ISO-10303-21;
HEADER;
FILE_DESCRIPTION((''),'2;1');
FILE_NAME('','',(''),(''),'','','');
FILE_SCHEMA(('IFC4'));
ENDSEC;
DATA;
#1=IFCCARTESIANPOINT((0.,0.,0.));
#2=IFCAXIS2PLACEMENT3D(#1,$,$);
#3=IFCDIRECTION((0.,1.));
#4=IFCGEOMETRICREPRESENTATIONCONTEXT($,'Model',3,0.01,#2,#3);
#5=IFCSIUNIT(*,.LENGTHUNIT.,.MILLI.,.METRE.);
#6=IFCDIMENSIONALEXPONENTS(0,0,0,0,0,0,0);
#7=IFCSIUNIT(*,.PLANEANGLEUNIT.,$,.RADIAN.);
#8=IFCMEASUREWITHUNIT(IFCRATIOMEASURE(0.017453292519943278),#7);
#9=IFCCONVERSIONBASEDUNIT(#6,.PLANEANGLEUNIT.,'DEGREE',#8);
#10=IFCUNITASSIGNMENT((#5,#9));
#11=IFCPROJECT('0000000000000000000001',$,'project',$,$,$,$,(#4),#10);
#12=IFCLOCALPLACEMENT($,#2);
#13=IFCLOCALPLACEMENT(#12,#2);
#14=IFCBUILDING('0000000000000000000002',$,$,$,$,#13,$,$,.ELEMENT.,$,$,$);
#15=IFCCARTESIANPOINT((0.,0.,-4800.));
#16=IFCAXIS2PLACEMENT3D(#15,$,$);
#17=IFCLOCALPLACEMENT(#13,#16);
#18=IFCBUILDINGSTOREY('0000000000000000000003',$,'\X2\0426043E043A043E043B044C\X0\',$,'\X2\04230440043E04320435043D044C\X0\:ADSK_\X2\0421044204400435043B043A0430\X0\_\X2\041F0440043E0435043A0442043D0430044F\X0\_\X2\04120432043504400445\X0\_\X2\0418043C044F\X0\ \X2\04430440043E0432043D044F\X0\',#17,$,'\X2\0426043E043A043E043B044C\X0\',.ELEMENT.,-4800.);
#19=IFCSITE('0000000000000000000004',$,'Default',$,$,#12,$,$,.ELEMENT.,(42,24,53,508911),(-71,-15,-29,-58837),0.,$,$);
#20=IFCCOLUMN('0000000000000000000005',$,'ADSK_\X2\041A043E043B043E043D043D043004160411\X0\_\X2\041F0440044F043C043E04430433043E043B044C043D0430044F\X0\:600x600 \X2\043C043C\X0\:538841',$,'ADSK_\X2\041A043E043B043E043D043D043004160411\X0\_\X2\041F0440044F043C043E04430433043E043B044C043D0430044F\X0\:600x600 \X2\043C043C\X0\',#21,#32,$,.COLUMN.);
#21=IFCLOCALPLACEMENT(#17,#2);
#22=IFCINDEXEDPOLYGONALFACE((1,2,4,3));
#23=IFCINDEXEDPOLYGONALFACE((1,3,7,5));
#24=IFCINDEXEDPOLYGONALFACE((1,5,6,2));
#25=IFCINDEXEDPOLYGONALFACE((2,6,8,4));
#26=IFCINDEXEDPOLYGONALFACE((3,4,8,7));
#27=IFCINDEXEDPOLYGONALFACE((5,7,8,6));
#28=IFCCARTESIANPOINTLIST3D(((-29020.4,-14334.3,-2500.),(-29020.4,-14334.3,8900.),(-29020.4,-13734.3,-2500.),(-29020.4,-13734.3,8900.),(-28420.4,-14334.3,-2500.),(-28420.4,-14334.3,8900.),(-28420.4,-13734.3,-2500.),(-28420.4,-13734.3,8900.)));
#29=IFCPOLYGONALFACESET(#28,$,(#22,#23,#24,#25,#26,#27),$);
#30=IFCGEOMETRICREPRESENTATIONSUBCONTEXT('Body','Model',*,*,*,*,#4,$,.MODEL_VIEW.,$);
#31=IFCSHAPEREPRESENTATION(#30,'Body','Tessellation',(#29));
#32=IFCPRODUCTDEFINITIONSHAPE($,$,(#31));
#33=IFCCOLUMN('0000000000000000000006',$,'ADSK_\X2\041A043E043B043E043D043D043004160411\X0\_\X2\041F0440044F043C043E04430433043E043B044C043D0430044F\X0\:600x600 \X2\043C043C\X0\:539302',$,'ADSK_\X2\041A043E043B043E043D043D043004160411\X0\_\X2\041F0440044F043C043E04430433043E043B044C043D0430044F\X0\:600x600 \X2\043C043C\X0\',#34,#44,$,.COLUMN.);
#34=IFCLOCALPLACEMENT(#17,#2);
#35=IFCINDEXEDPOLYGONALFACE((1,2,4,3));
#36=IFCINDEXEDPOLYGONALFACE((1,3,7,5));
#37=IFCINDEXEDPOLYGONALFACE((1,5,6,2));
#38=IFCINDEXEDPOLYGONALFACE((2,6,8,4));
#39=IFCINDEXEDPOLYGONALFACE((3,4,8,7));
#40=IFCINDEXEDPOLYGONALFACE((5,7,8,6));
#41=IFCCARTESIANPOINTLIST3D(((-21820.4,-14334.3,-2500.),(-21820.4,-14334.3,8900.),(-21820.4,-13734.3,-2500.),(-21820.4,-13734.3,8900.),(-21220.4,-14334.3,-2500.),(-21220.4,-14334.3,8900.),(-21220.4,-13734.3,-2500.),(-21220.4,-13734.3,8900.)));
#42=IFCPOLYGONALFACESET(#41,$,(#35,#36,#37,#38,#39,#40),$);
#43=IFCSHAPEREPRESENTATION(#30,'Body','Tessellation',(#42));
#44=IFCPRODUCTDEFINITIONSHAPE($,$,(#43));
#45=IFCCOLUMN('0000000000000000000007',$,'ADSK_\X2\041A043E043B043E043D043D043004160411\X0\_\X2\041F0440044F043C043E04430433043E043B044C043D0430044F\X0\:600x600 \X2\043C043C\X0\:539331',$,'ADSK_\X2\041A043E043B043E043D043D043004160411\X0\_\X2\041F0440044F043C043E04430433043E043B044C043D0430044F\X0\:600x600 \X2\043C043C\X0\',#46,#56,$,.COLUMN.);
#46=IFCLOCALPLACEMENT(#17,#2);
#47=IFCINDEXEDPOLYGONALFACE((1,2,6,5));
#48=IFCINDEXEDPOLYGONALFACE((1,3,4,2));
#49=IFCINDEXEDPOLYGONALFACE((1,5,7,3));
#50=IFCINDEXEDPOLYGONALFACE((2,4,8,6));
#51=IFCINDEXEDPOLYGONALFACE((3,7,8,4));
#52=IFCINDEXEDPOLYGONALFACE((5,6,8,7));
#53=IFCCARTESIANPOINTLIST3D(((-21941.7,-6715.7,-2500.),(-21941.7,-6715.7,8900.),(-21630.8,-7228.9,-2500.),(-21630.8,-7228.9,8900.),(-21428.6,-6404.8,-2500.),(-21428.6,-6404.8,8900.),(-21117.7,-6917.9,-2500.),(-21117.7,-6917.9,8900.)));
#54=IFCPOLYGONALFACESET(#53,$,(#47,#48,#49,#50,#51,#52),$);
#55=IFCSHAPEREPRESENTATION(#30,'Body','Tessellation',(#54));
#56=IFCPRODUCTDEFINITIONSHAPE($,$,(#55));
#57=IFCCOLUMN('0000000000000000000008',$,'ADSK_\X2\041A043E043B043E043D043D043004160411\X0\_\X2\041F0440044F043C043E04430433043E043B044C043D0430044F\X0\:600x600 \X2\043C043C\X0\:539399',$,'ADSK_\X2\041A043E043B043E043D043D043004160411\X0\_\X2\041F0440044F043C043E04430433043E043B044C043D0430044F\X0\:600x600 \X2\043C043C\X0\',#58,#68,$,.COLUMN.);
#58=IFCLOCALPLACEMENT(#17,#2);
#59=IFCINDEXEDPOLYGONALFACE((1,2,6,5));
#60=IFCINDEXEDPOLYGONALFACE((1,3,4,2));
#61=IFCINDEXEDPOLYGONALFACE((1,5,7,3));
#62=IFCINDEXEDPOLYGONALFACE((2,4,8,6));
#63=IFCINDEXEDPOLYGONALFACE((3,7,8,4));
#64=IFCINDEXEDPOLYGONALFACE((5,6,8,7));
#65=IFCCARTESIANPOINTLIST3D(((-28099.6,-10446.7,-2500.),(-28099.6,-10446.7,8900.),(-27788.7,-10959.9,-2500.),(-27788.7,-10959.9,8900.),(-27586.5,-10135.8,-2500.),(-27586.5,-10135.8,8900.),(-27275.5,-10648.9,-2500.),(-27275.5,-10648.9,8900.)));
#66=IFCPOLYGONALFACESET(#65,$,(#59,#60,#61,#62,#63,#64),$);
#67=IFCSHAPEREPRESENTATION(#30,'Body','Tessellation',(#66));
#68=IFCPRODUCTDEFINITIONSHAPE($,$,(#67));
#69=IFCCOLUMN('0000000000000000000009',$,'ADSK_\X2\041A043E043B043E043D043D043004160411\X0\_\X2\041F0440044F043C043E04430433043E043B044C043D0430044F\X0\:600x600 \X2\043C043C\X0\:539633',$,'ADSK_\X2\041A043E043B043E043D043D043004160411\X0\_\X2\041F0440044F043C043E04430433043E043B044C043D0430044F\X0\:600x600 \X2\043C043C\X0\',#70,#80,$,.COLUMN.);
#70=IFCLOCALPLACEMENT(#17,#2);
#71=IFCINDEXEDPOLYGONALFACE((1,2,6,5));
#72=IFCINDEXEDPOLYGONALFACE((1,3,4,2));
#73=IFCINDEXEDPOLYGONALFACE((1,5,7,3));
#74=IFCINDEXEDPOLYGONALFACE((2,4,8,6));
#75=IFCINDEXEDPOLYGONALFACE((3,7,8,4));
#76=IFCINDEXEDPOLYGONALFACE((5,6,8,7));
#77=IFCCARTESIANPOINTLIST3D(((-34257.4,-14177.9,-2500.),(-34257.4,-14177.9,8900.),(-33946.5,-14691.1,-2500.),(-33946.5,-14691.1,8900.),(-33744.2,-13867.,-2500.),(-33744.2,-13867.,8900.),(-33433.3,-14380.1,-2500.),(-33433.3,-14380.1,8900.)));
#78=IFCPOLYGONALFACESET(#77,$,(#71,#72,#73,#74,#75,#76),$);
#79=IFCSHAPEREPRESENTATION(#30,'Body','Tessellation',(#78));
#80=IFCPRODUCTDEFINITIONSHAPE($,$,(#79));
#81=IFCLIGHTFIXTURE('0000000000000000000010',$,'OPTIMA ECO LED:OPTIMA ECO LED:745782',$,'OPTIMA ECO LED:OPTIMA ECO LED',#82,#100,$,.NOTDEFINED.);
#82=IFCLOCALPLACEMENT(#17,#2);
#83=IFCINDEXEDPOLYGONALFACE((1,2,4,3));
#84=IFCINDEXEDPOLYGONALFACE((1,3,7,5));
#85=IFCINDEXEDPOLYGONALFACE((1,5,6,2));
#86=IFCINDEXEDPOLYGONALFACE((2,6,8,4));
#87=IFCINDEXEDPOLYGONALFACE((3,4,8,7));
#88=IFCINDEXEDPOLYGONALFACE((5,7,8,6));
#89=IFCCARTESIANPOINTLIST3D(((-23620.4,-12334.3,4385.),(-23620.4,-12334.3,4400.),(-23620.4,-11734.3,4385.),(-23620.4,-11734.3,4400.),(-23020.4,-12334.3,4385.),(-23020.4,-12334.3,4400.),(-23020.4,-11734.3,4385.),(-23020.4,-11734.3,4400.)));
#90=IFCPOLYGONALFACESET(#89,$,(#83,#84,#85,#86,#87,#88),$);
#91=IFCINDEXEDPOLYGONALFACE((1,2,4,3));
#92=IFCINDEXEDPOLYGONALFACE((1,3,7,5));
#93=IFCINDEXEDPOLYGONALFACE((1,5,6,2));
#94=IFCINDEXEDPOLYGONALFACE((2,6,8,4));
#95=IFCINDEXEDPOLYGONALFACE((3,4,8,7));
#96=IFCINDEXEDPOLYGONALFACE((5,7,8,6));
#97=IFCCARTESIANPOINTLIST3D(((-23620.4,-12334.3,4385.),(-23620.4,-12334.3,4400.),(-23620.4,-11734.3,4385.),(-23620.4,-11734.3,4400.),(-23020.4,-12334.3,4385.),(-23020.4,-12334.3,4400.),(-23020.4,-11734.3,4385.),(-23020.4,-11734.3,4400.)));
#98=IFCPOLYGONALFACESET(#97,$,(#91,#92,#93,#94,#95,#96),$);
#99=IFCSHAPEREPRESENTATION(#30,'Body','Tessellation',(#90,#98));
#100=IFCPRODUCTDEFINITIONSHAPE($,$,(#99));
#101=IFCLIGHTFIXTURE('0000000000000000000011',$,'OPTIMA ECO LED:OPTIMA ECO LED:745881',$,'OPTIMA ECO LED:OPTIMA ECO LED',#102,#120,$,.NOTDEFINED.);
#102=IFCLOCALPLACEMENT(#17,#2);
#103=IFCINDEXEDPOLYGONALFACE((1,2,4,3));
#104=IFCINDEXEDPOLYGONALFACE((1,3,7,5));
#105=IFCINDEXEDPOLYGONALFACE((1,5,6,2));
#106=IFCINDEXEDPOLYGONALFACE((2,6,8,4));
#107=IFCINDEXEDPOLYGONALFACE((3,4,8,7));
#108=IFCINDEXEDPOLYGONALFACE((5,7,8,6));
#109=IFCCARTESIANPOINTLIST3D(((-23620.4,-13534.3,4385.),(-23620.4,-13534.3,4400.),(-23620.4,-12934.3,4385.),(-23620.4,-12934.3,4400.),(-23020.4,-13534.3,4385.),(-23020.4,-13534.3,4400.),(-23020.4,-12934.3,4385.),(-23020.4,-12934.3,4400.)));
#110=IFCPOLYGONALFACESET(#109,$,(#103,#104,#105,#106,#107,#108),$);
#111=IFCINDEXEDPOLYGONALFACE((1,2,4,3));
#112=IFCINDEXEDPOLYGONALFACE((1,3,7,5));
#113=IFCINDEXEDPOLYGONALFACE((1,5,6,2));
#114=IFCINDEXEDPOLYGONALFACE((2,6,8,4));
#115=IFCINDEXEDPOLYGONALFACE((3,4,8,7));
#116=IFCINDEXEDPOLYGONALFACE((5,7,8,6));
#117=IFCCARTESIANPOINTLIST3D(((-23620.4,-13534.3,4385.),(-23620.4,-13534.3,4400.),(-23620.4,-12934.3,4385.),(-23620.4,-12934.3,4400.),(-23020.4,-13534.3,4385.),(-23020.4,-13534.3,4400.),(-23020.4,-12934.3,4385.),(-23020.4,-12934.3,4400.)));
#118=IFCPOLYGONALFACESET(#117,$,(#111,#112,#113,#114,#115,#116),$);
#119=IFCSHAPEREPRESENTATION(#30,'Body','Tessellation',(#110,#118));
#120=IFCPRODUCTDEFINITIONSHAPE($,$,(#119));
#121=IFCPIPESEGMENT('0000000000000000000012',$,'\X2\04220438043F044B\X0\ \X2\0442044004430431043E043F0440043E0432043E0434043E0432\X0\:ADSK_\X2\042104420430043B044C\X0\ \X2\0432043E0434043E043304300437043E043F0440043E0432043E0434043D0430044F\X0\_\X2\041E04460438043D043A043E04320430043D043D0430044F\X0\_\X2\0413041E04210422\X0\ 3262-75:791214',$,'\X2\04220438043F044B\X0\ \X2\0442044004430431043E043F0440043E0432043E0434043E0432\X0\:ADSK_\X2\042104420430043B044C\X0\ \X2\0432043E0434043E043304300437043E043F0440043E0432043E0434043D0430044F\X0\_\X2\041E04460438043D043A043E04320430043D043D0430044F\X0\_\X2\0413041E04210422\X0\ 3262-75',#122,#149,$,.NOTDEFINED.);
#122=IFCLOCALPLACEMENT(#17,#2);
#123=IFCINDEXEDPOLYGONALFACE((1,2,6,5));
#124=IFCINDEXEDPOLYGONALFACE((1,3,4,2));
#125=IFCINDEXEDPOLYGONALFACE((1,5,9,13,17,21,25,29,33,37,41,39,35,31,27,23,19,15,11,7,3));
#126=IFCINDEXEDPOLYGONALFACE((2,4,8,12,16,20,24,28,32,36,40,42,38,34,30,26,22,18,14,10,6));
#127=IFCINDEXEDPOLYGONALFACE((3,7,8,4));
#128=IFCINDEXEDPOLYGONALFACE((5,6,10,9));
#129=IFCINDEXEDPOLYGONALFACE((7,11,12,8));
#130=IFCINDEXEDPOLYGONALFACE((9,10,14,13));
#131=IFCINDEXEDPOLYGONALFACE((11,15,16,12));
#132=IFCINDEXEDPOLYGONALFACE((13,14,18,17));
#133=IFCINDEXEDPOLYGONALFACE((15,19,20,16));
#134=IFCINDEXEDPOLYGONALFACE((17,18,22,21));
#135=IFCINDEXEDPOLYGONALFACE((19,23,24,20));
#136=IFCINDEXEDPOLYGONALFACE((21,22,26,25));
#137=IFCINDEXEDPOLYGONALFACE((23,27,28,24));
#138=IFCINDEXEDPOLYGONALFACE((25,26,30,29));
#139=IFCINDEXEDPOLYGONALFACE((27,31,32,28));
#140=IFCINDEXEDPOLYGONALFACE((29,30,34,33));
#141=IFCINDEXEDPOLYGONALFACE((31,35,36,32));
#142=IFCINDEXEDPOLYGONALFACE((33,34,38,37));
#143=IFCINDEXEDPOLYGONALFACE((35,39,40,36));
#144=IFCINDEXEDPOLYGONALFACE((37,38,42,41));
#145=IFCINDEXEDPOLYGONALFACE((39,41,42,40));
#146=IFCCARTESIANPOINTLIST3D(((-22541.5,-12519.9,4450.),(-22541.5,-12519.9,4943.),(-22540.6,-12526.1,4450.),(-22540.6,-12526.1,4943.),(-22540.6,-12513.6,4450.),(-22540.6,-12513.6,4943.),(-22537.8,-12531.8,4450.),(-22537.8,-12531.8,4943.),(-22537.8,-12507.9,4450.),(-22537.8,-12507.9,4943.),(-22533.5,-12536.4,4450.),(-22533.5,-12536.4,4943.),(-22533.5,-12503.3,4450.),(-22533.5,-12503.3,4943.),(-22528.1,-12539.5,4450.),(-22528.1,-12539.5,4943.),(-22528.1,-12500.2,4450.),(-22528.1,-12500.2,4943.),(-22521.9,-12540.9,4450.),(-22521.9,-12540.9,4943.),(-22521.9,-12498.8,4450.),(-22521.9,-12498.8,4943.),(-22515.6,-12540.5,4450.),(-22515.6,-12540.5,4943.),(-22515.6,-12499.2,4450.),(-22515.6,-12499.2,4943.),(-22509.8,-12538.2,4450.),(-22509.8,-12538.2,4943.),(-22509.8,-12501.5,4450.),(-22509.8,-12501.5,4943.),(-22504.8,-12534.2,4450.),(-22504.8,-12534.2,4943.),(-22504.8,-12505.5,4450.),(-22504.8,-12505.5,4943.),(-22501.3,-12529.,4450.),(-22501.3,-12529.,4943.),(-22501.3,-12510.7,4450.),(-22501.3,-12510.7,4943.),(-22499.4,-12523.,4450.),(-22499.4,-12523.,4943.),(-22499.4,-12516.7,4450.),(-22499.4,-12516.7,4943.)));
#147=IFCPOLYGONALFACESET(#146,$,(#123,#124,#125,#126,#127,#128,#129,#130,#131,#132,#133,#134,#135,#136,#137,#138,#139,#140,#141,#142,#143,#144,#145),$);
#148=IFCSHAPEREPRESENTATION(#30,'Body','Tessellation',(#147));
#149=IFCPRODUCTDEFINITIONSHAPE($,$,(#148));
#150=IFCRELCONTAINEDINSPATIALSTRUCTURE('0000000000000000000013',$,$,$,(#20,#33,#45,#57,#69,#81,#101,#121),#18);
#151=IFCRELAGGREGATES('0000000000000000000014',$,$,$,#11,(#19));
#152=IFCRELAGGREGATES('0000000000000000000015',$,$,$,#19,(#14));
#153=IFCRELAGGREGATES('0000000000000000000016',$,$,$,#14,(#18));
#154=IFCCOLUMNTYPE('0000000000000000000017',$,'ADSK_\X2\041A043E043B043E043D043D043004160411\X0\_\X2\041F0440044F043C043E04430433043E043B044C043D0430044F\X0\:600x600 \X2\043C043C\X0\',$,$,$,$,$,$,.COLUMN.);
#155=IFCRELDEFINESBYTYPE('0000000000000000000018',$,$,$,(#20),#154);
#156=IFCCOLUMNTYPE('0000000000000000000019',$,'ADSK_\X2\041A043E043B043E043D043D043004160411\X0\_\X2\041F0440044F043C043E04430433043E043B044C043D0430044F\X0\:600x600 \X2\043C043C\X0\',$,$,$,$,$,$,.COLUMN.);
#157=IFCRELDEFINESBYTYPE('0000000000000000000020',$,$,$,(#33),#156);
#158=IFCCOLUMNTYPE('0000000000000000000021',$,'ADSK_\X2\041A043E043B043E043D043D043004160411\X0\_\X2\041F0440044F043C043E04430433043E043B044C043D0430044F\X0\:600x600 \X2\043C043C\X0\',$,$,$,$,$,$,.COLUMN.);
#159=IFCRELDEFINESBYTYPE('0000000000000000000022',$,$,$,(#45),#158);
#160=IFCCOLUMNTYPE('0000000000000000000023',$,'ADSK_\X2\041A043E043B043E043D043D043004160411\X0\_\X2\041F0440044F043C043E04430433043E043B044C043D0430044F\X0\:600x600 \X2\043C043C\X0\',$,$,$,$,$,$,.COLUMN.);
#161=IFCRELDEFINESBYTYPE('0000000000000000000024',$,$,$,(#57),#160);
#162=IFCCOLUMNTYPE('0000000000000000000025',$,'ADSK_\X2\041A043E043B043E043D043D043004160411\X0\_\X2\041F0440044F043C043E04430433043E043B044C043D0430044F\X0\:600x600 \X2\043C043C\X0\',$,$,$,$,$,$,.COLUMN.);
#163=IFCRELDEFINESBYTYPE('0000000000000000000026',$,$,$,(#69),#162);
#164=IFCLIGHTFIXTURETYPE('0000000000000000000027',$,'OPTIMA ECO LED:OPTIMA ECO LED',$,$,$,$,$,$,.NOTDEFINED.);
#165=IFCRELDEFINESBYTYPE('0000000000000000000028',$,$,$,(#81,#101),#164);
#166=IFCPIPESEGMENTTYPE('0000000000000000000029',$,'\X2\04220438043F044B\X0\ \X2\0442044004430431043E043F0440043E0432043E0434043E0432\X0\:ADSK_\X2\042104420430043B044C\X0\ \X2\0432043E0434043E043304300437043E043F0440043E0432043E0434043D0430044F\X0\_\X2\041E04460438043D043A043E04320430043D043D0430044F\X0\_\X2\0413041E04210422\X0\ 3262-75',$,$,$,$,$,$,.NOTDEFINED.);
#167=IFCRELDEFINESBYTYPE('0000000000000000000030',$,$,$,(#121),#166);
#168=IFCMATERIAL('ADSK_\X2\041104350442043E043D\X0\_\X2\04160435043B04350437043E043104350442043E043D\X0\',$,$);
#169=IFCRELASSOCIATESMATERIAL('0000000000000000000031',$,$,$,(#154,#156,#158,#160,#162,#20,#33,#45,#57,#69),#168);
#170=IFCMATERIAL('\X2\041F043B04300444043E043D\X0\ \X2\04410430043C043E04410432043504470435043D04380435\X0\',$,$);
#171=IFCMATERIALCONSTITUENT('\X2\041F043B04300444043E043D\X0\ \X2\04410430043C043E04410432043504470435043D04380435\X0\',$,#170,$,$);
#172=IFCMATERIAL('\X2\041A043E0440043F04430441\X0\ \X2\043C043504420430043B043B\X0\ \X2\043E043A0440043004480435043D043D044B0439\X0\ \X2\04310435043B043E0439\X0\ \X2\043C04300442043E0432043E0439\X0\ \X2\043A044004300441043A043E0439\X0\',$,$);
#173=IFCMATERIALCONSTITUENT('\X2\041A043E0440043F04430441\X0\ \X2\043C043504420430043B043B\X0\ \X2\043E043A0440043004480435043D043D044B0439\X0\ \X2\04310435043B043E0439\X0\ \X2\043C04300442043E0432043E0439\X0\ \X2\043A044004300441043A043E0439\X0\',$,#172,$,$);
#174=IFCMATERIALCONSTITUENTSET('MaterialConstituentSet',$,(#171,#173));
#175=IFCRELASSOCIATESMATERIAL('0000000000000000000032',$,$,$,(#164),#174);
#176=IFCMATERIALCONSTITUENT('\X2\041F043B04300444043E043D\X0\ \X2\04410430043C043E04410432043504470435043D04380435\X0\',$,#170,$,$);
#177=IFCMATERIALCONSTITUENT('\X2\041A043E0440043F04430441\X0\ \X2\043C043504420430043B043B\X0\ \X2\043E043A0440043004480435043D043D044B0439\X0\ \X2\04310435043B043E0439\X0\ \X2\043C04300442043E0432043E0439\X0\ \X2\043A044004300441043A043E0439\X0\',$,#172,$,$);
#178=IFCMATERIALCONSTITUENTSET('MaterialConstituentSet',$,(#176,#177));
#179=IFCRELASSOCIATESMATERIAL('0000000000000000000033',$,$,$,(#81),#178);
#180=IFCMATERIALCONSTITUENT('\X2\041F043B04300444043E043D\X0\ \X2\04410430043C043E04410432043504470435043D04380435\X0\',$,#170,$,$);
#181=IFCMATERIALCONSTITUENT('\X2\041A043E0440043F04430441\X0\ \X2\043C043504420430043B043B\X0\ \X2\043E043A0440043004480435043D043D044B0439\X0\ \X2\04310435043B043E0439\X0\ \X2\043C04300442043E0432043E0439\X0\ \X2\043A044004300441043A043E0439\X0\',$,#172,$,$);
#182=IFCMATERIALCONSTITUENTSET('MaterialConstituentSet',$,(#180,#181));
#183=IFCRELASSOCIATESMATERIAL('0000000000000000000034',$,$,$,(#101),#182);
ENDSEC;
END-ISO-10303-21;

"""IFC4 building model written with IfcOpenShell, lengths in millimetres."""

from ifc_helpers import new_model, entity, si_unit, converted_unit, direction, frame, frame_2d, origin, origin_2d_with_axis, place, context, subcontext, project, spatial, polyline, segment, composite_curve, rectangle, circle, outline, extrude, source, transform, mapped, material, constituent, constituent_set, material_profile, profile_set, profile_usage, type_object, type_shapes, element, save


model = new_model("IFC4")

# Units and contexts
model_context = context("Model", 3, precision=0.01, world=origin(), true_north=direction((0.0, 1.0)))
body_context = subcontext(model_context, "Body", "Model", "MODEL_VIEW")
ifc_project = project(units=[si_unit("LENGTHUNIT", "METRE", prefix="MILLI"), converted_unit("PLANEANGLEUNIT", "DEGREE", entity("IfcRatioMeasure", 0.017453292519943278), si_unit("PLANEANGLEUNIT", "RADIAN"), dimensions=[0, 0, 0, 0, 0, 0, 0])], contexts=[model_context])

# Site, building, storey
site_placement = place(None, origin())
site = spatial("IfcSite", under=ifc_project, at=site_placement, Name="Default", CompositionType="ELEMENT", RefLatitude=(42, 24, 53, 508911), RefLongitude=(-71, -15, -29, -58837), RefElevation=0.0)
building_placement = place(site_placement, origin())
building = spatial("IfcBuilding", under=site, at=building_placement, CompositionType="ELEMENT")
storey_placement = place(building_placement, frame((0.0, 0.0, -4800.0)))
storey = spatial("IfcBuildingStorey", under=building, at=storey_placement, Name="Цоколь", ObjectType="Уровень:ADSK_Стрелка_Проектная_Вверх_Имя уровня", LongName="Цоколь", CompositionType="ELEMENT", Elevation=-4800.0)

# Columns
ifc_material_1 = material(Name="ADSK_Бетон_Железобетон")
ifc_material_profile_1 = material_profile(ifc_material_1, outline(composite_curve([segment(polyline([(300.0, 300.0, 0.0), (300.0, -300.0, 0.0)]), True, "CONTINUOUS"), segment(polyline([(300.0, -300.0, 0.0), (-300.0, -300.0, 0.0)]), True, "CONTINUOUS"), segment(polyline([(-300.0, -300.0, 0.0), (-300.0, 300.0, 0.0)]), True, "CONTINUOUS"), segment(polyline([(-300.0, 300.0, 0.0), (300.0, 300.0, 0.0)]), True, "CONTINUOUS")], self_intersect=False), kind="CURVE"), Name="600x600 мм")
ifc_material_profile_2 = material_profile(ifc_material_1, outline(composite_curve([segment(polyline([(300.0, 300.0, -7300.0), (300.0, -300.0, -7300.0)]), True, "CONTINUOUS"), segment(polyline([(300.0, -300.0, -7300.0), (-300.0, -300.0, -7300.0)]), True, "CONTINUOUS"), segment(polyline([(-300.0, -300.0, -7300.0), (-300.0, 300.0, -7300.0)]), True, "CONTINUOUS"), segment(polyline([(-300.0, 300.0, -7300.0), (300.0, 300.0, -7300.0)]), True, "CONTINUOUS")], self_intersect=False), kind="CURVE"), Name="600x600 мм")
ifc_profile_set = profile_set([ifc_material_profile_1, ifc_material_profile_2], Name="600x600 мм")
ifc_profile_usage_1 = profile_usage(ifc_profile_set)
column_type_1 = type_object("IfcColumnType", Name="ADSK_КолоннаЖБ_Прямоугольная:600x600 мм", PredefinedType="COLUMN", material=ifc_profile_set)
shared_shape_1 = source(origin(), body_context, "Body", "SweptSolid", [
    extrude(rectangle(XDim=600.0, YDim=600.0, at=frame_2d((0.0, 0.0), x_axis=(1.0, 0.0))), frame((-28720.4, -14034.3, -7300.0), z_axis=(0.0, 0.0, 1.0), x_axis=(0.0, -1.0, 0.0)), (0.0, 0.0, 1.0), 11400.0),
])
type_shapes(column_type_1, [shared_shape_1])
column_1_placement = place(storey_placement, frame((0.0, 0.0, 4800.0)))
element("IfcColumn", 1, at=column_1_placement, inside=storey, type_object=column_type_1, material=ifc_profile_usage_1, Name="ADSK_КолоннаЖБ_Прямоугольная:600x600 мм:538841", ObjectType="ADSK_КолоннаЖБ_Прямоугольная:600x600 мм", PredefinedType="COLUMN", context=body_context, shape_type="MappedRepresentation", body=[
    mapped(shared_shape_1, transform((0.0, 0.0, 0.0), scale=1.0)),
])
ifc_profile_usage_2 = profile_usage(ifc_profile_set)
column_type_2 = type_object("IfcColumnType", Name="ADSK_КолоннаЖБ_Прямоугольная:600x600 мм", PredefinedType="COLUMN", material=ifc_profile_set)
shared_shape_2 = source(origin(), body_context, "Body", "SweptSolid", [
    extrude(rectangle(XDim=600.0, YDim=600.0, at=origin_2d_with_axis()), frame((0.0, 0.0, -7300.0), z_axis=(0.0, 0.0, 1.0), x_axis=(0.0, -1.0, 0.0)), (0.0, 0.0, 1.0), 11400.0),
])
type_shapes(column_type_2, [shared_shape_2])
column_2_placement = place(storey_placement, frame((-21520.4, -14034.3, 4800.0)))
element("IfcColumn", 2, at=column_2_placement, inside=storey, type_object=column_type_2, material=ifc_profile_usage_2, Name="ADSK_КолоннаЖБ_Прямоугольная:600x600 мм:539302", ObjectType="ADSK_КолоннаЖБ_Прямоугольная:600x600 мм", PredefinedType="COLUMN", context=body_context, shape_type="MappedRepresentation", body=[
    mapped(shared_shape_2, transform((0.0, 0.0, 0.0), scale=1.0)),
])
ifc_profile_usage_3 = profile_usage(ifc_profile_set)
column_type_3 = type_object("IfcColumnType", Name="ADSK_КолоннаЖБ_Прямоугольная:600x600 мм", PredefinedType="COLUMN", material=ifc_profile_set)
shared_shape_3 = source(origin(), body_context, "Body", "SweptSolid", [
    extrude(rectangle(XDim=600.0, YDim=600.0, at=frame_2d((0.0, 0.0), x_axis=(1.0, 0.0))), frame((-21529.7, -6816.8, -7300.0), z_axis=(0.0, 0.0, 1.0), x_axis=(-0.518223, 0.855246, 0.0)), (0.0, 0.0, 1.0), 11400.0),
])
type_shapes(column_type_3, [shared_shape_3])
column_3_placement = place(storey_placement, frame((0.0, 0.0, 4800.0)))
element("IfcColumn", 3, at=column_3_placement, inside=storey, type_object=column_type_3, material=ifc_profile_usage_3, Name="ADSK_КолоннаЖБ_Прямоугольная:600x600 мм:539331", ObjectType="ADSK_КолоннаЖБ_Прямоугольная:600x600 мм", PredefinedType="COLUMN", context=body_context, shape_type="MappedRepresentation", body=[
    mapped(shared_shape_3, transform((0.0, 0.0, 0.0), scale=1.0)),
])
ifc_profile_usage_4 = profile_usage(ifc_profile_set)
column_type_4 = type_object("IfcColumnType", Name="ADSK_КолоннаЖБ_Прямоугольная:600x600 мм", PredefinedType="COLUMN", material=ifc_profile_set)
shared_shape_4 = source(origin(), body_context, "Body", "SweptSolid", [
    extrude(rectangle(XDim=600.0, YDim=600.0, at=origin_2d_with_axis()), frame((-27687.6, -10547.8, -7300.0), z_axis=(0.0, 0.0, 1.0), x_axis=(-0.518223, 0.855246, 0.0)), (0.0, 0.0, 1.0), 11400.0),
])
type_shapes(column_type_4, [shared_shape_4])
column_4_placement = place(storey_placement, frame((0.0, 0.0, 4800.0)))
element("IfcColumn", 4, at=column_4_placement, inside=storey, type_object=column_type_4, material=ifc_profile_usage_4, Name="ADSK_КолоннаЖБ_Прямоугольная:600x600 мм:539399", ObjectType="ADSK_КолоннаЖБ_Прямоугольная:600x600 мм", PredefinedType="COLUMN", context=body_context, shape_type="MappedRepresentation", body=[
    mapped(shared_shape_4, transform((0.0, 0.0, 0.0), scale=1.0)),
])
ifc_profile_usage_5 = profile_usage(ifc_profile_set)
column_type_5 = type_object("IfcColumnType", Name="ADSK_КолоннаЖБ_Прямоугольная:600x600 мм", PredefinedType="COLUMN", material=ifc_profile_set)
shared_shape_5 = source(origin(), body_context, "Body", "SweptSolid", [
    extrude(rectangle(XDim=600.0, YDim=600.0, at=origin_2d_with_axis()), frame((-33845.4, -14279.0, -7300.0), z_axis=(0.0, 0.0, 1.0), x_axis=(-0.518223, 0.855246, 0.0)), (0.0, 0.0, 1.0), 11400.0),
])
type_shapes(column_type_5, [shared_shape_5])
column_5_placement = place(storey_placement, frame((0.0, 0.0, 4800.0)))
element("IfcColumn", 5, at=column_5_placement, inside=storey, type_object=column_type_5, material=ifc_profile_usage_5, Name="ADSK_КолоннаЖБ_Прямоугольная:600x600 мм:539633", ObjectType="ADSK_КолоннаЖБ_Прямоугольная:600x600 мм", PredefinedType="COLUMN", context=body_context, shape_type="MappedRepresentation", body=[
    mapped(shared_shape_5, transform((0.0, 0.0, 0.0), scale=1.0)),
])

# Light fixtures
ifc_material_2 = material(Name="Плафон самосвечение")
ifc_constituent_1 = constituent(ifc_material_2, Name="Плафон самосвечение")
ifc_material_3 = material(Name="Корпус металл окрашенный белой матовой краской")
ifc_constituent_2 = constituent(ifc_material_3, Name="Корпус металл окрашенный белой матовой краской")
ifc_constituent_set_1 = constituent_set(constituents=[ifc_constituent_1, ifc_constituent_2], Name="MaterialConstituentSet")
ifc_constituent_3 = constituent(ifc_material_2, Name="Плафон самосвечение")
ifc_constituent_4 = constituent(ifc_material_3, Name="Корпус металл окрашенный белой матовой краской")
ifc_constituent_set_2 = constituent_set(constituents=[ifc_constituent_3, ifc_constituent_4], Name="MaterialConstituentSet")
light_fixture_type = type_object("IfcLightFixtureType", Name="OPTIMA ECO LED:OPTIMA ECO LED", PredefinedType="NOTDEFINED", material=ifc_constituent_set_2)
shared_shape_6 = source(origin(), body_context, "Body", "SweptSolid", [
    extrude(rectangle(XDim=600.0, YDim=600.0, at=frame_2d((0.0, 0.0), x_axis=(1.0, 0.0))), frame((0.0, 0.0, -15.0)), (0.0, 0.0, 1.0), 15.0),
    extrude(rectangle(XDim=600.0, YDim=600.0, at=frame_2d((0.0, 0.0), x_axis=(1.0, 0.0))), frame((0.0, 0.0, -15.0)), (0.0, 0.0, 1.0), 15.0),
])
type_shapes(light_fixture_type, [shared_shape_6])
light_fixture_1_placement = place(storey_placement, frame((-23320.4, -12034.3, 4400.0)))
element("IfcLightFixture", 6, at=light_fixture_1_placement, inside=storey, type_object=light_fixture_type, material=ifc_constituent_set_1, Name="OPTIMA ECO LED:OPTIMA ECO LED:745782", ObjectType="OPTIMA ECO LED:OPTIMA ECO LED", PredefinedType="NOTDEFINED", context=body_context, shape_type="MappedRepresentation", body=[
    mapped(shared_shape_6, transform((0.0, 0.0, 0.0), scale=1.0)),
])
ifc_constituent_5 = constituent(ifc_material_2, Name="Плафон самосвечение")
ifc_constituent_6 = constituent(ifc_material_3, Name="Корпус металл окрашенный белой матовой краской")
ifc_constituent_set_3 = constituent_set(constituents=[ifc_constituent_5, ifc_constituent_6], Name="MaterialConstituentSet")
light_fixture_2_placement = place(storey_placement, frame((-23320.4, -13234.3, 4400.0)))
element("IfcLightFixture", 7, at=light_fixture_2_placement, inside=storey, type_object=light_fixture_type, material=ifc_constituent_set_3, Name="OPTIMA ECO LED:OPTIMA ECO LED:745881", ObjectType="OPTIMA ECO LED:OPTIMA ECO LED", PredefinedType="NOTDEFINED", context=body_context, shape_type="MappedRepresentation", body=[
    mapped(shared_shape_6, transform((0.0, 0.0, 0.0), scale=1.0)),
])

# Pipe segment
pipe_segment_type = type_object("IfcPipeSegmentType", Name="Типы трубопроводов:ADSK_Сталь водогазопроводная_Оцинкованная_ГОСТ 3262-75", PredefinedType="NOTDEFINED")
pipe_segment_1_placement = place(storey_placement, frame((-22543.1, -12542.6, 4943.0)))
element("IfcPipeSegment", 8, at=pipe_segment_1_placement, inside=storey, type_object=pipe_segment_type, Name="Типы трубопроводов:ADSK_Сталь водогазопроводная_Оцинкованная_ГОСТ 3262-75:791214", ObjectType="Типы трубопроводов:ADSK_Сталь водогазопроводная_Оцинкованная_ГОСТ 3262-75", PredefinedType="NOTDEFINED", context=body_context, shape_type="SweptSolid", body=[
    extrude(circle(Radius=21.1, at=origin_2d_with_axis()), frame((22.7, 22.7, -493.0), z_axis=(0.0, 0.0, 1.0), x_axis=(-1.0, 0.0, 0.0)), (0.0, 0.0, 1.0), 493.0),
])

save(model, "model.ifc")
